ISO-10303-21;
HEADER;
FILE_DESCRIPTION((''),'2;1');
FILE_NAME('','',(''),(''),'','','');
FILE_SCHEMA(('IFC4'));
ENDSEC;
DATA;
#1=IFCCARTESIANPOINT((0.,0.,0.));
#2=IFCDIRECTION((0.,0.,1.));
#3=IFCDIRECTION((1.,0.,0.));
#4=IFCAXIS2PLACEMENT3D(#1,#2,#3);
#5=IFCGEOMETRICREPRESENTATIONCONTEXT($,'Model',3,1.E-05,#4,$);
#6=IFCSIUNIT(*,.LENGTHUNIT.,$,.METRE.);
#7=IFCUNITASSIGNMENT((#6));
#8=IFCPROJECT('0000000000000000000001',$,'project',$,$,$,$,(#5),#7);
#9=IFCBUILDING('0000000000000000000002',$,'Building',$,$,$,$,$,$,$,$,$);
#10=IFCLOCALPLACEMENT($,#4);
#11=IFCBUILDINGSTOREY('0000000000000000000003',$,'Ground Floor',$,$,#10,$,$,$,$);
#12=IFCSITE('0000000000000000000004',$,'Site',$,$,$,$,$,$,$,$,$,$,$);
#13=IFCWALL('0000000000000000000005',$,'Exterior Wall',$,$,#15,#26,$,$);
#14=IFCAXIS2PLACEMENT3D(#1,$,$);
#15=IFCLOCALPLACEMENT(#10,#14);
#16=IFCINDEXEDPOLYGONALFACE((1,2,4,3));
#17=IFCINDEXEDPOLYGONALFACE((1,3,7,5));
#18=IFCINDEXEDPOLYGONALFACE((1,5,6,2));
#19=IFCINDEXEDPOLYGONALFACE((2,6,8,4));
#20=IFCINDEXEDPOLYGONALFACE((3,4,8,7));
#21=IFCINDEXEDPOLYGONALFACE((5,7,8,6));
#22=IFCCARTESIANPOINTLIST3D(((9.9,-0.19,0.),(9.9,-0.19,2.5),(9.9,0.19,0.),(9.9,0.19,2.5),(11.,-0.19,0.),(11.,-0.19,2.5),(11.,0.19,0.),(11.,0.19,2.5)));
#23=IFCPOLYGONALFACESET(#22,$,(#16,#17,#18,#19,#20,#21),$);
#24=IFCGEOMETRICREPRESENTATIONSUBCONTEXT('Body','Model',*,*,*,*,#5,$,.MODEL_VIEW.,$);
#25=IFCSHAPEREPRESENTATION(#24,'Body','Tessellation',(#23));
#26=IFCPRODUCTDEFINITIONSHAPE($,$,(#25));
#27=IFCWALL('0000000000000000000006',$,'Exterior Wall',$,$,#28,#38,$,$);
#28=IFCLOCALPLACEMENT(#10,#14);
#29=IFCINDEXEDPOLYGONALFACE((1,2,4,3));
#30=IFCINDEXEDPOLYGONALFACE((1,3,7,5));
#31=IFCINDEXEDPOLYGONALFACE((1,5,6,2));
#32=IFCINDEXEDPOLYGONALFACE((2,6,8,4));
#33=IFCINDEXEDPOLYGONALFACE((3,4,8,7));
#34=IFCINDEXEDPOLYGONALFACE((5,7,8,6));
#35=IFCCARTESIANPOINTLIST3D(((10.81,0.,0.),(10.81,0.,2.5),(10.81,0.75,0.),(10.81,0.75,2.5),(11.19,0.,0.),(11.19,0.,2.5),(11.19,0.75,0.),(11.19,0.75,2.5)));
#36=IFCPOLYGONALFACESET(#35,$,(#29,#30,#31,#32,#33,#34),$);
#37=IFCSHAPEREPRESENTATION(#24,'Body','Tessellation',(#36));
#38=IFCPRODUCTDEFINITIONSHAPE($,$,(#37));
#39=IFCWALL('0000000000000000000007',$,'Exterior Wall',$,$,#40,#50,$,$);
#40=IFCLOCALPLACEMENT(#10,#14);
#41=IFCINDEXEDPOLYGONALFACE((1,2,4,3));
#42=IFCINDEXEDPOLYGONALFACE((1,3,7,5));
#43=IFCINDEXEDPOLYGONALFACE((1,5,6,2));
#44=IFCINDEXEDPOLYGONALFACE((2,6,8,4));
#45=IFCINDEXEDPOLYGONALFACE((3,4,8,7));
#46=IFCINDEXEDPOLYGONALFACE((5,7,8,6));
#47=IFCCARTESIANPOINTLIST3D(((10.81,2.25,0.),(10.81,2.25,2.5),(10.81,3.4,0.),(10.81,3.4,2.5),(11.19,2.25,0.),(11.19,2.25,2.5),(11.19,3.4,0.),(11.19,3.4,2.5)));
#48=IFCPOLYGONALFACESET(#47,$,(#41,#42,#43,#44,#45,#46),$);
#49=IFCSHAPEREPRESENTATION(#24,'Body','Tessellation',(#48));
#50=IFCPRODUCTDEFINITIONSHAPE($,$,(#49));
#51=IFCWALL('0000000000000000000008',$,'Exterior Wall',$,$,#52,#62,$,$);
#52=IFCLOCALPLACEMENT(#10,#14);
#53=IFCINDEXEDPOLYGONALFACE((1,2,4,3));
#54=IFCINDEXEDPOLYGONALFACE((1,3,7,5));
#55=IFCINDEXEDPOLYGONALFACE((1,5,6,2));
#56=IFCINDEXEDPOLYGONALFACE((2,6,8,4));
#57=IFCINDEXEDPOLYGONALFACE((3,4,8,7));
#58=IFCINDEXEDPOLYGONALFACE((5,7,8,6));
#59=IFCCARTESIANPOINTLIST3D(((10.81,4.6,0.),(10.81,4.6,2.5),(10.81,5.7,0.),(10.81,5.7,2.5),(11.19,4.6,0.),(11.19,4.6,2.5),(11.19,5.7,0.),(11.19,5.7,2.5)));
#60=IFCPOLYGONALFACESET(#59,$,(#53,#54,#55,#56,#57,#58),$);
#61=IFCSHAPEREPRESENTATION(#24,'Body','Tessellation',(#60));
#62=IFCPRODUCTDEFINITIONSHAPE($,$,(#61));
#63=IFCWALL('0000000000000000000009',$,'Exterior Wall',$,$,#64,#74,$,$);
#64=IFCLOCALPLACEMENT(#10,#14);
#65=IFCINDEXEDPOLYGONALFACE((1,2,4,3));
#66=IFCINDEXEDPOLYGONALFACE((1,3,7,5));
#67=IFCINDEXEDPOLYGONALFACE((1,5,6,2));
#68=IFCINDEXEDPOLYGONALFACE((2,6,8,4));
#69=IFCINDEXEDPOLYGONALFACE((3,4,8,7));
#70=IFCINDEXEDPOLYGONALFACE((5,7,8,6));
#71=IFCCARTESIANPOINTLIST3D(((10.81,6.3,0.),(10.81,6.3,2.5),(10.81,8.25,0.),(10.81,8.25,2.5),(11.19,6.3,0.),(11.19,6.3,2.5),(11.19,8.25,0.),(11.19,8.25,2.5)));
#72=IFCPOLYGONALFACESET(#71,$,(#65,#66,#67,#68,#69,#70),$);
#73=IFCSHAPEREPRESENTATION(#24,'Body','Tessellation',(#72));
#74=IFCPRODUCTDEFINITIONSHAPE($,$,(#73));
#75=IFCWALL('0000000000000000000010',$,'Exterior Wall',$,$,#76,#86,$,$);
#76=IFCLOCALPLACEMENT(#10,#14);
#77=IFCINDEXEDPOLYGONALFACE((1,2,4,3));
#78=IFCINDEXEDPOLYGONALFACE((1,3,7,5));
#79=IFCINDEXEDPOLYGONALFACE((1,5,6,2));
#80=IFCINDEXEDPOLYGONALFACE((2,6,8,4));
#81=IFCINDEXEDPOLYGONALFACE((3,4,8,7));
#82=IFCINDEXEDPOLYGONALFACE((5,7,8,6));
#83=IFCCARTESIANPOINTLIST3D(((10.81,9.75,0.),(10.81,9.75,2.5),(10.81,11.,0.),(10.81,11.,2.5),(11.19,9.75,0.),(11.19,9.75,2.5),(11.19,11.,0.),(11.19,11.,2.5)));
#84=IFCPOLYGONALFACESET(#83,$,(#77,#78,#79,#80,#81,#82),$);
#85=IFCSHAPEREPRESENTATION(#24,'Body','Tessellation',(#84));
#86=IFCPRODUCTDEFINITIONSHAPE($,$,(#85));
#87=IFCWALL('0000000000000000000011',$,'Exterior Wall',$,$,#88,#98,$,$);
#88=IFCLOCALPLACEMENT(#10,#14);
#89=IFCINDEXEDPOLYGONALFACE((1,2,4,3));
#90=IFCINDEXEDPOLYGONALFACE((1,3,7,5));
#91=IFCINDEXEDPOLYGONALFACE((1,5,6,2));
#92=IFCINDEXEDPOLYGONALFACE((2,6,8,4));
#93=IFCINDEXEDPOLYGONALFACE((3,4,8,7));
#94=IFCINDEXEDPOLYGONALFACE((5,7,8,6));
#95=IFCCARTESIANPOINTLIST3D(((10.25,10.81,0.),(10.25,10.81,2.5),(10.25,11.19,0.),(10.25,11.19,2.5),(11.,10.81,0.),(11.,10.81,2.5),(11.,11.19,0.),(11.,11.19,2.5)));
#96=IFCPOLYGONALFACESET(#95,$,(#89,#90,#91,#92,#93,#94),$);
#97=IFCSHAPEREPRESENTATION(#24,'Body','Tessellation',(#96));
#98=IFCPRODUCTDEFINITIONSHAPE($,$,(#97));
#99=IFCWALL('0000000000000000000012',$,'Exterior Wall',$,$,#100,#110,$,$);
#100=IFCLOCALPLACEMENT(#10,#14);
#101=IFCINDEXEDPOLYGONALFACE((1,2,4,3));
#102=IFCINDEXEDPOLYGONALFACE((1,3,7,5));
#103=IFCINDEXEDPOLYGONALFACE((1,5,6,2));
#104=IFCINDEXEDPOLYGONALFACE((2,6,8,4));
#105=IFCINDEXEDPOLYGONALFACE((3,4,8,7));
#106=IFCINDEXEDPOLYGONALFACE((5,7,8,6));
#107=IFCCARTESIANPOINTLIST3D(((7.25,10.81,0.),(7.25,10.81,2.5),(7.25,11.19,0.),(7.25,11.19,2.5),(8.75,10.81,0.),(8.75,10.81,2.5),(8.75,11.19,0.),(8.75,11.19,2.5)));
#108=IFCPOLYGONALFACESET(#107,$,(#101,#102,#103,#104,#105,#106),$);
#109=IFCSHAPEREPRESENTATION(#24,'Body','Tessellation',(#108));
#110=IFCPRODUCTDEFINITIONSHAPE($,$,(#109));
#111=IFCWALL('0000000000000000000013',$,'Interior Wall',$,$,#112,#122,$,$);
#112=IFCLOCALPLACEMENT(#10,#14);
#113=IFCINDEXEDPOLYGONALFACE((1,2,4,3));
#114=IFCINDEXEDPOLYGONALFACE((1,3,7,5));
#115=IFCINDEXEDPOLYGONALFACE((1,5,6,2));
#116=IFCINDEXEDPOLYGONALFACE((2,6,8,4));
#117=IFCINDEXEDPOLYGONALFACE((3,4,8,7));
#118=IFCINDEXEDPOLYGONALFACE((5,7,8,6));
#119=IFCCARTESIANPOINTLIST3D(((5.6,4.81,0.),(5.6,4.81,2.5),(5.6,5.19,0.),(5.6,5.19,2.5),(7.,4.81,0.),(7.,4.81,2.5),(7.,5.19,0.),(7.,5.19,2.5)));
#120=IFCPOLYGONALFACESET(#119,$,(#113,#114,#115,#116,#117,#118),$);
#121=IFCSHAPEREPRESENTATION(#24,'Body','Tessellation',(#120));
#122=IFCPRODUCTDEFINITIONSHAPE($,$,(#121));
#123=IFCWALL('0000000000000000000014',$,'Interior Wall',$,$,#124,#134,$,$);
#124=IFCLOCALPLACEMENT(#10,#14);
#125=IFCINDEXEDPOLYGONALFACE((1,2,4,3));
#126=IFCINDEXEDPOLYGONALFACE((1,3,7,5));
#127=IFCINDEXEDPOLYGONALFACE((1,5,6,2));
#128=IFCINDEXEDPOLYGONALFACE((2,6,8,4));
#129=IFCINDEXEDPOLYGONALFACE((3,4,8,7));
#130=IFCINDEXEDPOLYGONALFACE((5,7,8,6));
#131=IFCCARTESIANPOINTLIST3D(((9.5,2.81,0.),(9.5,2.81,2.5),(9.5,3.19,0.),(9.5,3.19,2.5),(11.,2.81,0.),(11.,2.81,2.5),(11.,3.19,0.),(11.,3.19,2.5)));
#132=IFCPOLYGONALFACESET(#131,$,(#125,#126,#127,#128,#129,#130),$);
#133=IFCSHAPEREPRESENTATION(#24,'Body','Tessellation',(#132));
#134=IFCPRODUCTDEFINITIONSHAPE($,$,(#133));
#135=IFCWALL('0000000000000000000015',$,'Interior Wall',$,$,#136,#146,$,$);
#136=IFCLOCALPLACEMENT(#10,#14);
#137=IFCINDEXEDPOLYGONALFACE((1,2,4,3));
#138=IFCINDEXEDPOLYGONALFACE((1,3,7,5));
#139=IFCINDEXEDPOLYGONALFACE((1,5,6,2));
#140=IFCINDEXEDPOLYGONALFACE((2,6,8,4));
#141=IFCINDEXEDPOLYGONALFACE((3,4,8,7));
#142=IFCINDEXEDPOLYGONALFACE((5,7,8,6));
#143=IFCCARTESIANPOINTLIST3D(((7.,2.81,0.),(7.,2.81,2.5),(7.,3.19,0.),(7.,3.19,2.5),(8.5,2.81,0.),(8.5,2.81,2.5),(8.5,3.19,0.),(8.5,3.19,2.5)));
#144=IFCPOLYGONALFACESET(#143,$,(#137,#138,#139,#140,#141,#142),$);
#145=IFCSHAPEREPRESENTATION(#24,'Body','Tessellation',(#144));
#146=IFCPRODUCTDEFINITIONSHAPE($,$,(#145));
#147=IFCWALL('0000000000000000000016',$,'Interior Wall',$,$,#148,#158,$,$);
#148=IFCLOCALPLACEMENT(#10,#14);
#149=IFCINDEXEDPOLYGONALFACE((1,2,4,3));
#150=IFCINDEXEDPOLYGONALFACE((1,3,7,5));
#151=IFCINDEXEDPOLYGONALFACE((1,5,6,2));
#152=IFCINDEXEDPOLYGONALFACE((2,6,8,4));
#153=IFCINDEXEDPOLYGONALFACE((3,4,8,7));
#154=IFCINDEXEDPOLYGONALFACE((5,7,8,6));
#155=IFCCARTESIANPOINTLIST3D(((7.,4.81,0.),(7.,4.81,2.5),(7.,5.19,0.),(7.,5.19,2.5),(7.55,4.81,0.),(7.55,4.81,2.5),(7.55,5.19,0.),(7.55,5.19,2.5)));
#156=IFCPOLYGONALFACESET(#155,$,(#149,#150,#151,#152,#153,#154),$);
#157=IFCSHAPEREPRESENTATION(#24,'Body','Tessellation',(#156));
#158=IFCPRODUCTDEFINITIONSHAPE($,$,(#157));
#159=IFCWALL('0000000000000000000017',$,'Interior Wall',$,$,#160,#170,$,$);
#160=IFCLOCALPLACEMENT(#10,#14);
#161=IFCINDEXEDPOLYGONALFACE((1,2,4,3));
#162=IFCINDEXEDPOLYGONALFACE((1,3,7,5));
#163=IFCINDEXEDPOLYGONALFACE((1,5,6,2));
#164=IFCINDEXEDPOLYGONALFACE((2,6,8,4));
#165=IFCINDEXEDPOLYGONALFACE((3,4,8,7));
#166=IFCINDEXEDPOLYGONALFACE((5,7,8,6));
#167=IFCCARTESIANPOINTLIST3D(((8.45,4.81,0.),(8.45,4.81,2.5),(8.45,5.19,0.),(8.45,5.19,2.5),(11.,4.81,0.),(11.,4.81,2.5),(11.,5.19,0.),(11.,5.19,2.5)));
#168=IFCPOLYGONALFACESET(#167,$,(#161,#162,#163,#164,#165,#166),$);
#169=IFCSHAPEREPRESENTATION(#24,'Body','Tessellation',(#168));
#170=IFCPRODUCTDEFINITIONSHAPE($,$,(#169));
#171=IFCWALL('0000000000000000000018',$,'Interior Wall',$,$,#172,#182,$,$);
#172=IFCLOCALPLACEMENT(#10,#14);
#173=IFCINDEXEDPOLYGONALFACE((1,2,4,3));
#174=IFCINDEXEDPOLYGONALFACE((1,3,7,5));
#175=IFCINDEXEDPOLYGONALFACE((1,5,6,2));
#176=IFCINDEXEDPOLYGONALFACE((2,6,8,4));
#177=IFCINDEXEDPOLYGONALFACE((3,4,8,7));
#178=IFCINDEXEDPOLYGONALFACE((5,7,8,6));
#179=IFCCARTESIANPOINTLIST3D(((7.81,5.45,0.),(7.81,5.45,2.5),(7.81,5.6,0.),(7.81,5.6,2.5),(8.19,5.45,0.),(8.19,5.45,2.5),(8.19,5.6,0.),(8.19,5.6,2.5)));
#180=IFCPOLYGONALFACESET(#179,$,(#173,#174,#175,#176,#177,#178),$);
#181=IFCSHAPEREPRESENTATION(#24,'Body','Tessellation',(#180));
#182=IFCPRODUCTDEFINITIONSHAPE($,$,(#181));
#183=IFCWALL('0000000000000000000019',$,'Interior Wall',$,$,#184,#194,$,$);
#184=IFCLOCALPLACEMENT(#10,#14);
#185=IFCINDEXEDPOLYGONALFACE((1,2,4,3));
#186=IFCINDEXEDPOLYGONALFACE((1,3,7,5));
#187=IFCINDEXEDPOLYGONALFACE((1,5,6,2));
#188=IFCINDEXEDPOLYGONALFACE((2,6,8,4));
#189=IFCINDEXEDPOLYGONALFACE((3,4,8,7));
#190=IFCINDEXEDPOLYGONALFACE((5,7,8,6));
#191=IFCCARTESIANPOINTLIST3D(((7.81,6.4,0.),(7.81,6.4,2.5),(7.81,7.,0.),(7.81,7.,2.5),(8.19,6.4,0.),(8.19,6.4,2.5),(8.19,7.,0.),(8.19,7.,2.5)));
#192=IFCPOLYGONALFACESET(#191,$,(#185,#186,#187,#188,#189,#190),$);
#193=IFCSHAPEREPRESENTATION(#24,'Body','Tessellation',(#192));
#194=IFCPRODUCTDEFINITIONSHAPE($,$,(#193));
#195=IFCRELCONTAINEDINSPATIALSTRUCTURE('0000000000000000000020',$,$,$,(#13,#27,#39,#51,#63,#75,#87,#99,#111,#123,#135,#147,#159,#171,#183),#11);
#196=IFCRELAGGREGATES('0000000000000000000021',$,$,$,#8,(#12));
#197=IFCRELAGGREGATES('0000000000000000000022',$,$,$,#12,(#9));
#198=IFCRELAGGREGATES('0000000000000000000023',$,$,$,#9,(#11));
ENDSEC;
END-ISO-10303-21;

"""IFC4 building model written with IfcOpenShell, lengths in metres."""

from ifc_helpers import new_model, si_unit, frame, origin_with_axes, place, context, subcontext, project, spatial, indexed_curve, outline, extrude, element, save


model = new_model("IFC4")

# Units and contexts
model_context = context("Model", 3, precision=1e-05, world=origin_with_axes())
body_context = subcontext(model_context, "Body", "Model", "MODEL_VIEW")
ifc_project = project(units=[si_unit("LENGTHUNIT", "METRE")], contexts=[model_context])

# Site, building, storey
site = spatial("IfcSite", under=ifc_project, Name="Site")
building = spatial("IfcBuilding", under=site, Name="Building")
storey_placement = place(None, origin_with_axes())
storey = spatial("IfcBuildingStorey", under=building, at=storey_placement, Name="Ground Floor")

# Walls
wall_1_placement = place(storey_placement, frame((9.9, 0.0, 0.0), z_axis=(0.0, 0.0, 1.0), x_axis=(1.0, 0.0, 0.0)))
element("IfcWall", 1, at=wall_1_placement, inside=storey, Name="Exterior Wall", context=body_context, shape_type="SweptSolid", body=[
    extrude(outline(indexed_curve([(0.0, 0.0), (0.0, 0.38), (1.1, 0.38), (1.1, 0.0), (0.0, 0.0)], self_intersect=False)), frame((0.0, -0.19, 0.0), z_axis=(0.0, 0.0, 1.0), x_axis=(1.0, 0.0, 0.0)), (0.0, 0.0, 1.0), 2.5),
])
wall_2_placement = place(storey_placement, frame((11.0, 0.0, 0.0), z_axis=(0.0, 0.0, 1.0), x_axis=(0.0, 1.0, 0.0)))
element("IfcWall", 2, at=wall_2_placement, inside=storey, Name="Exterior Wall", context=body_context, shape_type="SweptSolid", body=[
    extrude(outline(indexed_curve([(0.0, 0.0), (0.0, 0.38), (0.75, 0.38), (0.75, 0.0), (0.0, 0.0)], self_intersect=False)), frame((0.0, -0.19, 0.0), z_axis=(0.0, 0.0, 1.0), x_axis=(1.0, 0.0, 0.0)), (0.0, 0.0, 1.0), 2.5),
])
wall_3_placement = place(storey_placement, frame((11.0, 2.25, 0.0), z_axis=(0.0, 0.0, 1.0), x_axis=(0.0, 1.0, 0.0)))
element("IfcWall", 3, at=wall_3_placement, inside=storey, Name="Exterior Wall", context=body_context, shape_type="SweptSolid", body=[
    extrude(outline(indexed_curve([(0.0, 0.0), (0.0, 0.38), (1.15, 0.38), (1.15, 0.0), (0.0, 0.0)], self_intersect=False)), frame((0.0, -0.19, 0.0), z_axis=(0.0, 0.0, 1.0), x_axis=(1.0, 0.0, 0.0)), (0.0, 0.0, 1.0), 2.5),
])
wall_4_placement = place(storey_placement, frame((11.0, 4.6, 0.0), z_axis=(0.0, 0.0, 1.0), x_axis=(0.0, 1.0, 0.0)))
element("IfcWall", 4, at=wall_4_placement, inside=storey, Name="Exterior Wall", context=body_context, shape_type="SweptSolid", body=[
    extrude(outline(indexed_curve([(0.0, 0.0), (0.0, 0.38), (1.1, 0.38), (1.1, 0.0), (0.0, 0.0)], self_intersect=False)), frame((0.0, -0.19, 0.0), z_axis=(0.0, 0.0, 1.0), x_axis=(1.0, 0.0, 0.0)), (0.0, 0.0, 1.0), 2.5),
])
wall_5_placement = place(storey_placement, frame((11.0, 6.3, 0.0), z_axis=(0.0, 0.0, 1.0), x_axis=(0.0, 1.0, 0.0)))
element("IfcWall", 5, at=wall_5_placement, inside=storey, Name="Exterior Wall", context=body_context, shape_type="SweptSolid", body=[
    extrude(outline(indexed_curve([(0.0, 0.0), (0.0, 0.38), (1.95, 0.38), (1.95, 0.0), (0.0, 0.0)], self_intersect=False)), frame((0.0, -0.19, 0.0), z_axis=(0.0, 0.0, 1.0), x_axis=(1.0, 0.0, 0.0)), (0.0, 0.0, 1.0), 2.5),
])
wall_6_placement = place(storey_placement, frame((11.0, 9.75, 0.0), z_axis=(0.0, 0.0, 1.0), x_axis=(0.0, 1.0, 0.0)))
element("IfcWall", 6, at=wall_6_placement, inside=storey, Name="Exterior Wall", context=body_context, shape_type="SweptSolid", body=[
    extrude(outline(indexed_curve([(0.0, 0.0), (0.0, 0.38), (1.25, 0.38), (1.25, 0.0), (0.0, 0.0)], self_intersect=False)), frame((0.0, -0.19, 0.0), z_axis=(0.0, 0.0, 1.0), x_axis=(1.0, 0.0, 0.0)), (0.0, 0.0, 1.0), 2.5),
])
wall_7_placement = place(storey_placement, frame((11.0, 11.0, 0.0), z_axis=(0.0, 0.0, 1.0), x_axis=(-1.0, 0.0, 0.0)))
element("IfcWall", 7, at=wall_7_placement, inside=storey, Name="Exterior Wall", context=body_context, shape_type="SweptSolid", body=[
    extrude(outline(indexed_curve([(0.0, 0.0), (0.0, 0.38), (0.75, 0.38), (0.75, 0.0), (0.0, 0.0)], self_intersect=False)), frame((0.0, -0.19, 0.0), z_axis=(0.0, 0.0, 1.0), x_axis=(1.0, 0.0, 0.0)), (0.0, 0.0, 1.0), 2.5),
])
wall_8_placement = place(storey_placement, frame((8.75, 11.0, 0.0), z_axis=(0.0, 0.0, 1.0), x_axis=(-1.0, 0.0, 0.0)))
element("IfcWall", 8, at=wall_8_placement, inside=storey, Name="Exterior Wall", context=body_context, shape_type="SweptSolid", body=[
    extrude(outline(indexed_curve([(0.0, 0.0), (0.0, 0.38), (1.5, 0.38), (1.5, 0.0), (0.0, 0.0)], self_intersect=False)), frame((0.0, -0.19, 0.0), z_axis=(0.0, 0.0, 1.0), x_axis=(1.0, 0.0, 0.0)), (0.0, 0.0, 1.0), 2.5),
])
wall_9_placement = place(storey_placement, frame((7.0, 5.0, 0.0), z_axis=(0.0, 0.0, 1.0), x_axis=(-1.0, 0.0, 0.0)))
element("IfcWall", 9, at=wall_9_placement, inside=storey, Name="Interior Wall", context=body_context, shape_type="SweptSolid", body=[
    extrude(outline(indexed_curve([(0.0, 0.0), (0.0, 0.38), (1.4, 0.38), (1.4, 0.0), (0.0, 0.0)], self_intersect=False)), frame((0.0, -0.19, 0.0), z_axis=(0.0, 0.0, 1.0), x_axis=(1.0, 0.0, 0.0)), (0.0, 0.0, 1.0), 2.5),
])
for number, where, z_axis, x_axis, name in (
    (10, (11.0, 3.0, 0.0), (0.0, 0.0, 1.0), (-1.0, 0.0, 0.0), "Interior Wall"),
    (11, (8.5, 3.0, 0.0), (0.0, 0.0, 1.0), (-1.0, 0.0, 0.0), "Interior Wall"),
):
    element("IfcWall", number, at=place(storey_placement, frame(where, z_axis=z_axis, x_axis=x_axis)), inside=storey, Name=name, context=body_context, shape_type="SweptSolid", body=[
        extrude(outline(indexed_curve([(0.0, 0.0), (0.0, 0.38), (1.5, 0.38), (1.5, 0.0), (0.0, 0.0)], self_intersect=False)), frame((0.0, -0.19, 0.0), z_axis=(0.0, 0.0, 1.0), x_axis=(1.0, 0.0, 0.0)), (0.0, 0.0, 1.0), 2.5),
    ])
wall_10_placement = place(storey_placement, frame((7.55, 5.0, 0.0), z_axis=(0.0, 0.0, 1.0), x_axis=(-1.0, 0.0, 0.0)))
element("IfcWall", 12, at=wall_10_placement, inside=storey, Name="Interior Wall", context=body_context, shape_type="SweptSolid", body=[
    extrude(outline(indexed_curve([(0.0, 0.0), (0.0, 0.38), (0.55, 0.38), (0.55, 0.0), (0.0, 0.0)], self_intersect=False)), frame((0.0, -0.19, 0.0), z_axis=(0.0, 0.0, 1.0), x_axis=(1.0, 0.0, 0.0)), (0.0, 0.0, 1.0), 2.5),
])
wall_11_placement = place(storey_placement, frame((11.0, 5.0, 0.0), z_axis=(0.0, 0.0, 1.0), x_axis=(-1.0, 0.0, 0.0)))
element("IfcWall", 13, at=wall_11_placement, inside=storey, Name="Interior Wall", context=body_context, shape_type="SweptSolid", body=[
    extrude(outline(indexed_curve([(0.0, 0.0), (0.0, 0.38), (2.55, 0.38), (2.55, 0.0), (0.0, 0.0)], self_intersect=False)), frame((0.0, -0.19, 0.0), z_axis=(0.0, 0.0, 1.0), x_axis=(1.0, 0.0, 0.0)), (0.0, 0.0, 1.0), 2.5),
])
wall_12_placement = place(storey_placement, frame((8.0, 5.45, 0.0), z_axis=(0.0, 0.0, 1.0), x_axis=(0.0, 1.0, 0.0)))
element("IfcWall", 14, at=wall_12_placement, inside=storey, Name="Interior Wall", context=body_context, shape_type="SweptSolid", body=[
    extrude(outline(indexed_curve([(0.0, 0.0), (0.0, 0.38), (0.15, 0.38), (0.15, 0.0), (0.0, 0.0)], self_intersect=False)), frame((0.0, -0.19, 0.0), z_axis=(0.0, 0.0, 1.0), x_axis=(1.0, 0.0, 0.0)), (0.0, 0.0, 1.0), 2.5),
])
wall_13_placement = place(storey_placement, frame((8.0, 6.4, 0.0), z_axis=(0.0, 0.0, 1.0), x_axis=(0.0, 1.0, 0.0)))
element("IfcWall", 15, at=wall_13_placement, inside=storey, Name="Interior Wall", context=body_context, shape_type="SweptSolid", body=[
    extrude(outline(indexed_curve([(0.0, 0.0), (0.0, 0.38), (0.6, 0.38), (0.6, 0.0), (0.0, 0.0)], self_intersect=False)), frame((0.0, -0.19, 0.0), z_axis=(0.0, 0.0, 1.0), x_axis=(1.0, 0.0, 0.0)), (0.0, 0.0, 1.0), 2.5),
])

save(model, "model.ifc")
